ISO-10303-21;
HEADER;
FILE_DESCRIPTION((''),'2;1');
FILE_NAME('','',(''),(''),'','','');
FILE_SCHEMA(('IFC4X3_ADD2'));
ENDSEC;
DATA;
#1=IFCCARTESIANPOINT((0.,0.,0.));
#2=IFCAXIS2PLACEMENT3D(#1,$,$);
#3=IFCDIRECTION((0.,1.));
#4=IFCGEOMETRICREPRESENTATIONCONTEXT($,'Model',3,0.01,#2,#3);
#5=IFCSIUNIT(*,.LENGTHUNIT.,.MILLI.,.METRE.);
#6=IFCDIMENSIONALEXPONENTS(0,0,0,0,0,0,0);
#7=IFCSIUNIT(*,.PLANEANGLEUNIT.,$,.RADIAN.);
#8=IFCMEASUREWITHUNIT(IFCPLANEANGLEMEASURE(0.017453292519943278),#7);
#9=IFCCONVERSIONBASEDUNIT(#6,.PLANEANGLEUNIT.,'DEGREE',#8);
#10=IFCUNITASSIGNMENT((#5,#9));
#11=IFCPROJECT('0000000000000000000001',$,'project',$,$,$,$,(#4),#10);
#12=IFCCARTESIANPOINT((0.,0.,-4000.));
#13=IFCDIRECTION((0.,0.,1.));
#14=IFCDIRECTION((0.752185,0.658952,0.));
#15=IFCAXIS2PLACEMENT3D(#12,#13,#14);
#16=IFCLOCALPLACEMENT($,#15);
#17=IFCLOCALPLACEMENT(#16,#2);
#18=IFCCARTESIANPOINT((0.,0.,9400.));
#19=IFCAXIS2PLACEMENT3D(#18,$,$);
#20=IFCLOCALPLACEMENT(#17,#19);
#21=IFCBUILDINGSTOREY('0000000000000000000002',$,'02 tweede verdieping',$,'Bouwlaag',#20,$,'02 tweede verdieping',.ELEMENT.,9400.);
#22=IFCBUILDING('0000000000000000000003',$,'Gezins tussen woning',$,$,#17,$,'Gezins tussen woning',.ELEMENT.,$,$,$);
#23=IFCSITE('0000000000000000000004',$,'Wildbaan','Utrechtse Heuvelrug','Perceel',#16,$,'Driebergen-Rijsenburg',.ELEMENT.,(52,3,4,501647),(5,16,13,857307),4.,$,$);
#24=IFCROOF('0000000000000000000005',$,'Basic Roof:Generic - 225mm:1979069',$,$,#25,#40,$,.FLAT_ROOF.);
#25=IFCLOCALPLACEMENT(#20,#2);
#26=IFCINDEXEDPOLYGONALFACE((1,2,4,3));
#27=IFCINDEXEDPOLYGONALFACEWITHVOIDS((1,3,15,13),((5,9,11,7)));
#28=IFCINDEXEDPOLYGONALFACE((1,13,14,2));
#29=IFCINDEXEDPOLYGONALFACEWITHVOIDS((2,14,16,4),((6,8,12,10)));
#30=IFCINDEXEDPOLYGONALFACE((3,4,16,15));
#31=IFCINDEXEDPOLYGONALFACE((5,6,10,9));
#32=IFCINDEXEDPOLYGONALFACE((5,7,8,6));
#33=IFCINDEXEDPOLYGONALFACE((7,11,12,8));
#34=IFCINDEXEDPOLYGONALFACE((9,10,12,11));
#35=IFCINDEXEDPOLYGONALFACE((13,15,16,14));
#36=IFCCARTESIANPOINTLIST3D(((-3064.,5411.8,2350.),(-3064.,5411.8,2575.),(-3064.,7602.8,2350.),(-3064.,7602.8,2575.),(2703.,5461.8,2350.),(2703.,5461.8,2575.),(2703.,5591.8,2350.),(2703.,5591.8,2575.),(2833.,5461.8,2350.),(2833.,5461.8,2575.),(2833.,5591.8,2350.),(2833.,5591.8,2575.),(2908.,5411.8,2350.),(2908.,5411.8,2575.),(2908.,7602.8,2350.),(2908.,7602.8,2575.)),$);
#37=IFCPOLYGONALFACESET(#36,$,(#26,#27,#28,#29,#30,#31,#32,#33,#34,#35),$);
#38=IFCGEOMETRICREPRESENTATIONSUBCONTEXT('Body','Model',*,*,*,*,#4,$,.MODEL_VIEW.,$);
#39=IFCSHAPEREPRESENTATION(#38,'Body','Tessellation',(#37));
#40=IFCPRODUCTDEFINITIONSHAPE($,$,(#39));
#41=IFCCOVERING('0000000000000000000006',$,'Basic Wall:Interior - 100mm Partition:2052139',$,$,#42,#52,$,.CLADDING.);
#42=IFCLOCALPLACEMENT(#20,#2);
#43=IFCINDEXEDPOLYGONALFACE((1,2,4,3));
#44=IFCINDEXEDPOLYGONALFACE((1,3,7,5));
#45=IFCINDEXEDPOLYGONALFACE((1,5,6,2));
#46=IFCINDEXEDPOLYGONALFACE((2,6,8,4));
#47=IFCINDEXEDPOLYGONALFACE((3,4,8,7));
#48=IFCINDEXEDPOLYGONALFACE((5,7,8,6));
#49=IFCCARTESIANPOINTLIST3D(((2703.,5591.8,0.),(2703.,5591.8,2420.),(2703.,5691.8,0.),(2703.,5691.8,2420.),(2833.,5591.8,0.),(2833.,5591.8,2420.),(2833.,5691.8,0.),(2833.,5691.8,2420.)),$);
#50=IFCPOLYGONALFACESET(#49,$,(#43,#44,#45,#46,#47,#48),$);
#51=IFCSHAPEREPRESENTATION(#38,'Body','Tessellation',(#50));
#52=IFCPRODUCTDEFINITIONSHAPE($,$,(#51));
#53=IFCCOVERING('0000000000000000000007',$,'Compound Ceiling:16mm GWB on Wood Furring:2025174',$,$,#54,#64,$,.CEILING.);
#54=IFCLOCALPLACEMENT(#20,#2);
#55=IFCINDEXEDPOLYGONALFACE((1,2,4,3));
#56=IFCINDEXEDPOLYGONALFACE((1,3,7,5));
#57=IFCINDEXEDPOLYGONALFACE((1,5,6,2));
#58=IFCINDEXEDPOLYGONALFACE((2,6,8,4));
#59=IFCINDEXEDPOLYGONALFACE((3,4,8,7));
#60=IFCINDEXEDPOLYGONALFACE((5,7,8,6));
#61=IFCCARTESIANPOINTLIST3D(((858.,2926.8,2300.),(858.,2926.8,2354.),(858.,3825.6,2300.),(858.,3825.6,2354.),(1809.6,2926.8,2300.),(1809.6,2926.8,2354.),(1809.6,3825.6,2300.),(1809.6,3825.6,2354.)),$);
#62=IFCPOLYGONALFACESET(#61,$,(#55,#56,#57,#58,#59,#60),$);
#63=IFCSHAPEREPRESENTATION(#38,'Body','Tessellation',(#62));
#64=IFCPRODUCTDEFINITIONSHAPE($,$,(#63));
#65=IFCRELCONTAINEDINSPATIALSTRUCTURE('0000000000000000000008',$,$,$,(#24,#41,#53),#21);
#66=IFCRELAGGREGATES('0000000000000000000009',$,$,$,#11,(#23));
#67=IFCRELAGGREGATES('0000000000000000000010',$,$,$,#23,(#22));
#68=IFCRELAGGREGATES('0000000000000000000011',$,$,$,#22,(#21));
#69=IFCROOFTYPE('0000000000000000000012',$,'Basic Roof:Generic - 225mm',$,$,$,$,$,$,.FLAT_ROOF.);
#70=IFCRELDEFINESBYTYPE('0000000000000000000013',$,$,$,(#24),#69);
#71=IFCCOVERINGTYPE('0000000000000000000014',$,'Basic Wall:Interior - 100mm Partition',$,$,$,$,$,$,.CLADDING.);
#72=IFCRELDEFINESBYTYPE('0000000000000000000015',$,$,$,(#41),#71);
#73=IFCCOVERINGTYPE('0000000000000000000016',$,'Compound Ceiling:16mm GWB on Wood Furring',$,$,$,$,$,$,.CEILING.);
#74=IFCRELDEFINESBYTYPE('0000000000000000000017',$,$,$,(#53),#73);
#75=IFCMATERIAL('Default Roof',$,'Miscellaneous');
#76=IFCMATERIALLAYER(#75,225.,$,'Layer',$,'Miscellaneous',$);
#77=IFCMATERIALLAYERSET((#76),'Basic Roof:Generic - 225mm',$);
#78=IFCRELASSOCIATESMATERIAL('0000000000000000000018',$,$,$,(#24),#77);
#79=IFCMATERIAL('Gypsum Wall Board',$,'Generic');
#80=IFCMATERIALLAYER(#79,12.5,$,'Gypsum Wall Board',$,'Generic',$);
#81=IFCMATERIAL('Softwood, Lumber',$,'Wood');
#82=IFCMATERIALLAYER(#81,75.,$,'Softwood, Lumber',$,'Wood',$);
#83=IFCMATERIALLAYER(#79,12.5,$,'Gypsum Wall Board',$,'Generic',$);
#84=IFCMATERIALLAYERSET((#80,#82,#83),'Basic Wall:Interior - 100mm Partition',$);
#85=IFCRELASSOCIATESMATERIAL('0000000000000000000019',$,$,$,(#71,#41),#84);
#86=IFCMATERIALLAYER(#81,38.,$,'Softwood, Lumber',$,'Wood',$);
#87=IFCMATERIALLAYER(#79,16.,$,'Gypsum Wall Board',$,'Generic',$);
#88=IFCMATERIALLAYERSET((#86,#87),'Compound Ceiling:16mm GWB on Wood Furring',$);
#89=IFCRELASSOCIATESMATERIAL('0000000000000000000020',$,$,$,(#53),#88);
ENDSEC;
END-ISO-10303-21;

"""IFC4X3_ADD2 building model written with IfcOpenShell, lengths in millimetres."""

from ifc_helpers import new_model, entity, si_unit, converted_unit, direction, frame, frame_2d, origin, place, context, subcontext, project, spatial, rectangle, extrude, material, layer, layer_set, layer_usage, type_object, element, save


model = new_model("IFC4X3_ADD2")

# Units and contexts
model_context = context("Model", 3, precision=0.01, world=origin(), true_north=direction((0.0, 1.0)))
body_context = subcontext(model_context, "Body", "Model", "MODEL_VIEW")
ifc_project = project(units=[si_unit("LENGTHUNIT", "METRE", prefix="MILLI"), converted_unit("PLANEANGLEUNIT", "DEGREE", entity("IfcPlaneAngleMeasure", 0.017453292519943278), si_unit("PLANEANGLEUNIT", "RADIAN"), dimensions=[0, 0, 0, 0, 0, 0, 0])], contexts=[model_context])

# Site, building, storey
site_placement = place(None, frame((0.0, 0.0, -4000.0), z_axis=(0.0, 0.0, 1.0), x_axis=(0.752185, 0.658952, 0.0)))
site = spatial("IfcSite", under=ifc_project, at=site_placement, Name="Wildbaan", Description="Utrechtse Heuvelrug", ObjectType="Perceel", LongName="Driebergen-Rijsenburg", CompositionType="ELEMENT", RefLatitude=(52, 3, 4, 501647), RefLongitude=(5, 16, 13, 857307), RefElevation=4.0)
building_placement = place(site_placement, origin())
building = spatial("IfcBuilding", under=site, at=building_placement, Name="Gezins tussen woning", LongName="Gezins tussen woning", CompositionType="ELEMENT")
storey_placement = place(building_placement, frame((0.0, 0.0, 9400.0)))
storey = spatial("IfcBuildingStorey", under=building, at=storey_placement, Name="02 tweede verdieping", ObjectType="Bouwlaag", LongName="02 tweede verdieping", CompositionType="ELEMENT", Elevation=9400.0)

# Roof, opening
ifc_material_1 = material(Name="Default Roof", Category="Miscellaneous")
ifc_layer_1 = layer(ifc_material_1, 225.0, Name="Layer", Category="Miscellaneous")
ifc_layer_set_1 = layer_set([ifc_layer_1], Name="Basic Roof:Generic - 225mm")
roof_type = type_object("IfcRoofType", Name="Basic Roof:Generic - 225mm", PredefinedType="FLAT_ROOF")
roof_placement = place(storey_placement, frame((-3064.0, 5411.8, 2350.0)))
roof = element("IfcRoof", 1, at=roof_placement, inside=storey, type_object=roof_type, material=ifc_layer_set_1, Name="Basic Roof:Generic - 225mm:1979069", PredefinedType="FLAT_ROOF", context=body_context, shape_type="SweptSolid", body=[
    extrude(rectangle(XDim=5972.0, YDim=2191.0, at=frame_2d((0.0, 0.0), x_axis=(1.0, 0.0))), frame((2986.0, 1095.5, 0.0), z_axis=(0.0, 0.0, 1.0), x_axis=(-1.0, 0.0, 0.0)), (0.0, 0.0, 1.0), 225.0),
])
opening_placement = place(storey_placement, frame((-3064.0, 5411.8, 2350.0)))
element("IfcOpeningElement", 2, at=opening_placement, cuts=roof, PredefinedType="OPENING", context=body_context, shape_type="SweptSolid", body=[
    extrude(rectangle(XDim=130.0, YDim=130.0, at=frame_2d((0.0, 0.0), x_axis=(1.0, 0.0))), frame((5832.0, 115.0, 0.0), z_axis=(0.0, 0.0, 1.0), x_axis=(0.0, -1.0, 0.0)), (0.0, 0.0, 1.0), 225.0),
])

# Coverings
ifc_material_2 = material(Name="Gypsum Wall Board", Category="Generic")
ifc_layer_2 = layer(ifc_material_2, 12.5, Name="Gypsum Wall Board", Category="Generic")
ifc_material_3 = material(Name="Softwood, Lumber", Category="Wood")
ifc_layer_3 = layer(ifc_material_3, 75.0, Name="Softwood, Lumber", Category="Wood")
ifc_layer_4 = layer(ifc_material_2, 12.5, Name="Gypsum Wall Board", Category="Generic")
ifc_layer_set_2 = layer_set([ifc_layer_2, ifc_layer_3, ifc_layer_4], Name="Basic Wall:Interior - 100mm Partition")
ifc_layer_usage_1 = layer_usage(ifc_layer_set_2, "AXIS2", "NEGATIVE", 50.0)
covering_type_1 = type_object("IfcCoveringType", Name="Basic Wall:Interior - 100mm Partition", PredefinedType="CLADDING", material=ifc_layer_set_2)
covering_1_placement = place(storey_placement, frame((2703.0, 5641.8, 0.0)))
element("IfcCovering", 3, at=covering_1_placement, inside=storey, type_object=covering_type_1, material=ifc_layer_usage_1, Name="Basic Wall:Interior - 100mm Partition:2052139", PredefinedType="CLADDING", context=body_context, shape_type="SweptSolid", body=[
    extrude(rectangle(XDim=130.0, YDim=100.0, at=frame_2d((65.0, 0.0), x_axis=(-1.0, 0.0))), origin(), (0.0, 0.0, 1.0), 2420.0),
])
ifc_layer_5 = layer(ifc_material_3, 38.0, Name="Softwood, Lumber", Category="Wood")
ifc_layer_6 = layer(ifc_material_2, 16.0, Name="Gypsum Wall Board", Category="Generic")
ifc_layer_set_3 = layer_set([ifc_layer_5, ifc_layer_6], Name="Compound Ceiling:16mm GWB on Wood Furring")
covering_type_2 = type_object("IfcCoveringType", Name="Compound Ceiling:16mm GWB on Wood Furring", PredefinedType="CEILING")
ifc_layer_usage_2 = layer_usage(ifc_layer_set_3, "AXIS3", "NEGATIVE", 0.0)
covering_2_placement = place(storey_placement, frame((858.0, 2926.8, 2300.0)))
element("IfcCovering", 4, at=covering_2_placement, inside=storey, type_object=covering_type_2, material=ifc_layer_usage_2, Name="Compound Ceiling:16mm GWB on Wood Furring:2025174", PredefinedType="CEILING", context=body_context, shape_type="SweptSolid", body=[
    extrude(rectangle(XDim=898.8, YDim=951.6, at=frame_2d((0.0, 0.0), x_axis=(1.0, 0.0))), frame((475.8, 449.4, 0.0), z_axis=(0.0, 0.0, 1.0), x_axis=(0.0, 1.0, 0.0)), (0.0, 0.0, 1.0), 54.0),
])

save(model, "model.ifc")
